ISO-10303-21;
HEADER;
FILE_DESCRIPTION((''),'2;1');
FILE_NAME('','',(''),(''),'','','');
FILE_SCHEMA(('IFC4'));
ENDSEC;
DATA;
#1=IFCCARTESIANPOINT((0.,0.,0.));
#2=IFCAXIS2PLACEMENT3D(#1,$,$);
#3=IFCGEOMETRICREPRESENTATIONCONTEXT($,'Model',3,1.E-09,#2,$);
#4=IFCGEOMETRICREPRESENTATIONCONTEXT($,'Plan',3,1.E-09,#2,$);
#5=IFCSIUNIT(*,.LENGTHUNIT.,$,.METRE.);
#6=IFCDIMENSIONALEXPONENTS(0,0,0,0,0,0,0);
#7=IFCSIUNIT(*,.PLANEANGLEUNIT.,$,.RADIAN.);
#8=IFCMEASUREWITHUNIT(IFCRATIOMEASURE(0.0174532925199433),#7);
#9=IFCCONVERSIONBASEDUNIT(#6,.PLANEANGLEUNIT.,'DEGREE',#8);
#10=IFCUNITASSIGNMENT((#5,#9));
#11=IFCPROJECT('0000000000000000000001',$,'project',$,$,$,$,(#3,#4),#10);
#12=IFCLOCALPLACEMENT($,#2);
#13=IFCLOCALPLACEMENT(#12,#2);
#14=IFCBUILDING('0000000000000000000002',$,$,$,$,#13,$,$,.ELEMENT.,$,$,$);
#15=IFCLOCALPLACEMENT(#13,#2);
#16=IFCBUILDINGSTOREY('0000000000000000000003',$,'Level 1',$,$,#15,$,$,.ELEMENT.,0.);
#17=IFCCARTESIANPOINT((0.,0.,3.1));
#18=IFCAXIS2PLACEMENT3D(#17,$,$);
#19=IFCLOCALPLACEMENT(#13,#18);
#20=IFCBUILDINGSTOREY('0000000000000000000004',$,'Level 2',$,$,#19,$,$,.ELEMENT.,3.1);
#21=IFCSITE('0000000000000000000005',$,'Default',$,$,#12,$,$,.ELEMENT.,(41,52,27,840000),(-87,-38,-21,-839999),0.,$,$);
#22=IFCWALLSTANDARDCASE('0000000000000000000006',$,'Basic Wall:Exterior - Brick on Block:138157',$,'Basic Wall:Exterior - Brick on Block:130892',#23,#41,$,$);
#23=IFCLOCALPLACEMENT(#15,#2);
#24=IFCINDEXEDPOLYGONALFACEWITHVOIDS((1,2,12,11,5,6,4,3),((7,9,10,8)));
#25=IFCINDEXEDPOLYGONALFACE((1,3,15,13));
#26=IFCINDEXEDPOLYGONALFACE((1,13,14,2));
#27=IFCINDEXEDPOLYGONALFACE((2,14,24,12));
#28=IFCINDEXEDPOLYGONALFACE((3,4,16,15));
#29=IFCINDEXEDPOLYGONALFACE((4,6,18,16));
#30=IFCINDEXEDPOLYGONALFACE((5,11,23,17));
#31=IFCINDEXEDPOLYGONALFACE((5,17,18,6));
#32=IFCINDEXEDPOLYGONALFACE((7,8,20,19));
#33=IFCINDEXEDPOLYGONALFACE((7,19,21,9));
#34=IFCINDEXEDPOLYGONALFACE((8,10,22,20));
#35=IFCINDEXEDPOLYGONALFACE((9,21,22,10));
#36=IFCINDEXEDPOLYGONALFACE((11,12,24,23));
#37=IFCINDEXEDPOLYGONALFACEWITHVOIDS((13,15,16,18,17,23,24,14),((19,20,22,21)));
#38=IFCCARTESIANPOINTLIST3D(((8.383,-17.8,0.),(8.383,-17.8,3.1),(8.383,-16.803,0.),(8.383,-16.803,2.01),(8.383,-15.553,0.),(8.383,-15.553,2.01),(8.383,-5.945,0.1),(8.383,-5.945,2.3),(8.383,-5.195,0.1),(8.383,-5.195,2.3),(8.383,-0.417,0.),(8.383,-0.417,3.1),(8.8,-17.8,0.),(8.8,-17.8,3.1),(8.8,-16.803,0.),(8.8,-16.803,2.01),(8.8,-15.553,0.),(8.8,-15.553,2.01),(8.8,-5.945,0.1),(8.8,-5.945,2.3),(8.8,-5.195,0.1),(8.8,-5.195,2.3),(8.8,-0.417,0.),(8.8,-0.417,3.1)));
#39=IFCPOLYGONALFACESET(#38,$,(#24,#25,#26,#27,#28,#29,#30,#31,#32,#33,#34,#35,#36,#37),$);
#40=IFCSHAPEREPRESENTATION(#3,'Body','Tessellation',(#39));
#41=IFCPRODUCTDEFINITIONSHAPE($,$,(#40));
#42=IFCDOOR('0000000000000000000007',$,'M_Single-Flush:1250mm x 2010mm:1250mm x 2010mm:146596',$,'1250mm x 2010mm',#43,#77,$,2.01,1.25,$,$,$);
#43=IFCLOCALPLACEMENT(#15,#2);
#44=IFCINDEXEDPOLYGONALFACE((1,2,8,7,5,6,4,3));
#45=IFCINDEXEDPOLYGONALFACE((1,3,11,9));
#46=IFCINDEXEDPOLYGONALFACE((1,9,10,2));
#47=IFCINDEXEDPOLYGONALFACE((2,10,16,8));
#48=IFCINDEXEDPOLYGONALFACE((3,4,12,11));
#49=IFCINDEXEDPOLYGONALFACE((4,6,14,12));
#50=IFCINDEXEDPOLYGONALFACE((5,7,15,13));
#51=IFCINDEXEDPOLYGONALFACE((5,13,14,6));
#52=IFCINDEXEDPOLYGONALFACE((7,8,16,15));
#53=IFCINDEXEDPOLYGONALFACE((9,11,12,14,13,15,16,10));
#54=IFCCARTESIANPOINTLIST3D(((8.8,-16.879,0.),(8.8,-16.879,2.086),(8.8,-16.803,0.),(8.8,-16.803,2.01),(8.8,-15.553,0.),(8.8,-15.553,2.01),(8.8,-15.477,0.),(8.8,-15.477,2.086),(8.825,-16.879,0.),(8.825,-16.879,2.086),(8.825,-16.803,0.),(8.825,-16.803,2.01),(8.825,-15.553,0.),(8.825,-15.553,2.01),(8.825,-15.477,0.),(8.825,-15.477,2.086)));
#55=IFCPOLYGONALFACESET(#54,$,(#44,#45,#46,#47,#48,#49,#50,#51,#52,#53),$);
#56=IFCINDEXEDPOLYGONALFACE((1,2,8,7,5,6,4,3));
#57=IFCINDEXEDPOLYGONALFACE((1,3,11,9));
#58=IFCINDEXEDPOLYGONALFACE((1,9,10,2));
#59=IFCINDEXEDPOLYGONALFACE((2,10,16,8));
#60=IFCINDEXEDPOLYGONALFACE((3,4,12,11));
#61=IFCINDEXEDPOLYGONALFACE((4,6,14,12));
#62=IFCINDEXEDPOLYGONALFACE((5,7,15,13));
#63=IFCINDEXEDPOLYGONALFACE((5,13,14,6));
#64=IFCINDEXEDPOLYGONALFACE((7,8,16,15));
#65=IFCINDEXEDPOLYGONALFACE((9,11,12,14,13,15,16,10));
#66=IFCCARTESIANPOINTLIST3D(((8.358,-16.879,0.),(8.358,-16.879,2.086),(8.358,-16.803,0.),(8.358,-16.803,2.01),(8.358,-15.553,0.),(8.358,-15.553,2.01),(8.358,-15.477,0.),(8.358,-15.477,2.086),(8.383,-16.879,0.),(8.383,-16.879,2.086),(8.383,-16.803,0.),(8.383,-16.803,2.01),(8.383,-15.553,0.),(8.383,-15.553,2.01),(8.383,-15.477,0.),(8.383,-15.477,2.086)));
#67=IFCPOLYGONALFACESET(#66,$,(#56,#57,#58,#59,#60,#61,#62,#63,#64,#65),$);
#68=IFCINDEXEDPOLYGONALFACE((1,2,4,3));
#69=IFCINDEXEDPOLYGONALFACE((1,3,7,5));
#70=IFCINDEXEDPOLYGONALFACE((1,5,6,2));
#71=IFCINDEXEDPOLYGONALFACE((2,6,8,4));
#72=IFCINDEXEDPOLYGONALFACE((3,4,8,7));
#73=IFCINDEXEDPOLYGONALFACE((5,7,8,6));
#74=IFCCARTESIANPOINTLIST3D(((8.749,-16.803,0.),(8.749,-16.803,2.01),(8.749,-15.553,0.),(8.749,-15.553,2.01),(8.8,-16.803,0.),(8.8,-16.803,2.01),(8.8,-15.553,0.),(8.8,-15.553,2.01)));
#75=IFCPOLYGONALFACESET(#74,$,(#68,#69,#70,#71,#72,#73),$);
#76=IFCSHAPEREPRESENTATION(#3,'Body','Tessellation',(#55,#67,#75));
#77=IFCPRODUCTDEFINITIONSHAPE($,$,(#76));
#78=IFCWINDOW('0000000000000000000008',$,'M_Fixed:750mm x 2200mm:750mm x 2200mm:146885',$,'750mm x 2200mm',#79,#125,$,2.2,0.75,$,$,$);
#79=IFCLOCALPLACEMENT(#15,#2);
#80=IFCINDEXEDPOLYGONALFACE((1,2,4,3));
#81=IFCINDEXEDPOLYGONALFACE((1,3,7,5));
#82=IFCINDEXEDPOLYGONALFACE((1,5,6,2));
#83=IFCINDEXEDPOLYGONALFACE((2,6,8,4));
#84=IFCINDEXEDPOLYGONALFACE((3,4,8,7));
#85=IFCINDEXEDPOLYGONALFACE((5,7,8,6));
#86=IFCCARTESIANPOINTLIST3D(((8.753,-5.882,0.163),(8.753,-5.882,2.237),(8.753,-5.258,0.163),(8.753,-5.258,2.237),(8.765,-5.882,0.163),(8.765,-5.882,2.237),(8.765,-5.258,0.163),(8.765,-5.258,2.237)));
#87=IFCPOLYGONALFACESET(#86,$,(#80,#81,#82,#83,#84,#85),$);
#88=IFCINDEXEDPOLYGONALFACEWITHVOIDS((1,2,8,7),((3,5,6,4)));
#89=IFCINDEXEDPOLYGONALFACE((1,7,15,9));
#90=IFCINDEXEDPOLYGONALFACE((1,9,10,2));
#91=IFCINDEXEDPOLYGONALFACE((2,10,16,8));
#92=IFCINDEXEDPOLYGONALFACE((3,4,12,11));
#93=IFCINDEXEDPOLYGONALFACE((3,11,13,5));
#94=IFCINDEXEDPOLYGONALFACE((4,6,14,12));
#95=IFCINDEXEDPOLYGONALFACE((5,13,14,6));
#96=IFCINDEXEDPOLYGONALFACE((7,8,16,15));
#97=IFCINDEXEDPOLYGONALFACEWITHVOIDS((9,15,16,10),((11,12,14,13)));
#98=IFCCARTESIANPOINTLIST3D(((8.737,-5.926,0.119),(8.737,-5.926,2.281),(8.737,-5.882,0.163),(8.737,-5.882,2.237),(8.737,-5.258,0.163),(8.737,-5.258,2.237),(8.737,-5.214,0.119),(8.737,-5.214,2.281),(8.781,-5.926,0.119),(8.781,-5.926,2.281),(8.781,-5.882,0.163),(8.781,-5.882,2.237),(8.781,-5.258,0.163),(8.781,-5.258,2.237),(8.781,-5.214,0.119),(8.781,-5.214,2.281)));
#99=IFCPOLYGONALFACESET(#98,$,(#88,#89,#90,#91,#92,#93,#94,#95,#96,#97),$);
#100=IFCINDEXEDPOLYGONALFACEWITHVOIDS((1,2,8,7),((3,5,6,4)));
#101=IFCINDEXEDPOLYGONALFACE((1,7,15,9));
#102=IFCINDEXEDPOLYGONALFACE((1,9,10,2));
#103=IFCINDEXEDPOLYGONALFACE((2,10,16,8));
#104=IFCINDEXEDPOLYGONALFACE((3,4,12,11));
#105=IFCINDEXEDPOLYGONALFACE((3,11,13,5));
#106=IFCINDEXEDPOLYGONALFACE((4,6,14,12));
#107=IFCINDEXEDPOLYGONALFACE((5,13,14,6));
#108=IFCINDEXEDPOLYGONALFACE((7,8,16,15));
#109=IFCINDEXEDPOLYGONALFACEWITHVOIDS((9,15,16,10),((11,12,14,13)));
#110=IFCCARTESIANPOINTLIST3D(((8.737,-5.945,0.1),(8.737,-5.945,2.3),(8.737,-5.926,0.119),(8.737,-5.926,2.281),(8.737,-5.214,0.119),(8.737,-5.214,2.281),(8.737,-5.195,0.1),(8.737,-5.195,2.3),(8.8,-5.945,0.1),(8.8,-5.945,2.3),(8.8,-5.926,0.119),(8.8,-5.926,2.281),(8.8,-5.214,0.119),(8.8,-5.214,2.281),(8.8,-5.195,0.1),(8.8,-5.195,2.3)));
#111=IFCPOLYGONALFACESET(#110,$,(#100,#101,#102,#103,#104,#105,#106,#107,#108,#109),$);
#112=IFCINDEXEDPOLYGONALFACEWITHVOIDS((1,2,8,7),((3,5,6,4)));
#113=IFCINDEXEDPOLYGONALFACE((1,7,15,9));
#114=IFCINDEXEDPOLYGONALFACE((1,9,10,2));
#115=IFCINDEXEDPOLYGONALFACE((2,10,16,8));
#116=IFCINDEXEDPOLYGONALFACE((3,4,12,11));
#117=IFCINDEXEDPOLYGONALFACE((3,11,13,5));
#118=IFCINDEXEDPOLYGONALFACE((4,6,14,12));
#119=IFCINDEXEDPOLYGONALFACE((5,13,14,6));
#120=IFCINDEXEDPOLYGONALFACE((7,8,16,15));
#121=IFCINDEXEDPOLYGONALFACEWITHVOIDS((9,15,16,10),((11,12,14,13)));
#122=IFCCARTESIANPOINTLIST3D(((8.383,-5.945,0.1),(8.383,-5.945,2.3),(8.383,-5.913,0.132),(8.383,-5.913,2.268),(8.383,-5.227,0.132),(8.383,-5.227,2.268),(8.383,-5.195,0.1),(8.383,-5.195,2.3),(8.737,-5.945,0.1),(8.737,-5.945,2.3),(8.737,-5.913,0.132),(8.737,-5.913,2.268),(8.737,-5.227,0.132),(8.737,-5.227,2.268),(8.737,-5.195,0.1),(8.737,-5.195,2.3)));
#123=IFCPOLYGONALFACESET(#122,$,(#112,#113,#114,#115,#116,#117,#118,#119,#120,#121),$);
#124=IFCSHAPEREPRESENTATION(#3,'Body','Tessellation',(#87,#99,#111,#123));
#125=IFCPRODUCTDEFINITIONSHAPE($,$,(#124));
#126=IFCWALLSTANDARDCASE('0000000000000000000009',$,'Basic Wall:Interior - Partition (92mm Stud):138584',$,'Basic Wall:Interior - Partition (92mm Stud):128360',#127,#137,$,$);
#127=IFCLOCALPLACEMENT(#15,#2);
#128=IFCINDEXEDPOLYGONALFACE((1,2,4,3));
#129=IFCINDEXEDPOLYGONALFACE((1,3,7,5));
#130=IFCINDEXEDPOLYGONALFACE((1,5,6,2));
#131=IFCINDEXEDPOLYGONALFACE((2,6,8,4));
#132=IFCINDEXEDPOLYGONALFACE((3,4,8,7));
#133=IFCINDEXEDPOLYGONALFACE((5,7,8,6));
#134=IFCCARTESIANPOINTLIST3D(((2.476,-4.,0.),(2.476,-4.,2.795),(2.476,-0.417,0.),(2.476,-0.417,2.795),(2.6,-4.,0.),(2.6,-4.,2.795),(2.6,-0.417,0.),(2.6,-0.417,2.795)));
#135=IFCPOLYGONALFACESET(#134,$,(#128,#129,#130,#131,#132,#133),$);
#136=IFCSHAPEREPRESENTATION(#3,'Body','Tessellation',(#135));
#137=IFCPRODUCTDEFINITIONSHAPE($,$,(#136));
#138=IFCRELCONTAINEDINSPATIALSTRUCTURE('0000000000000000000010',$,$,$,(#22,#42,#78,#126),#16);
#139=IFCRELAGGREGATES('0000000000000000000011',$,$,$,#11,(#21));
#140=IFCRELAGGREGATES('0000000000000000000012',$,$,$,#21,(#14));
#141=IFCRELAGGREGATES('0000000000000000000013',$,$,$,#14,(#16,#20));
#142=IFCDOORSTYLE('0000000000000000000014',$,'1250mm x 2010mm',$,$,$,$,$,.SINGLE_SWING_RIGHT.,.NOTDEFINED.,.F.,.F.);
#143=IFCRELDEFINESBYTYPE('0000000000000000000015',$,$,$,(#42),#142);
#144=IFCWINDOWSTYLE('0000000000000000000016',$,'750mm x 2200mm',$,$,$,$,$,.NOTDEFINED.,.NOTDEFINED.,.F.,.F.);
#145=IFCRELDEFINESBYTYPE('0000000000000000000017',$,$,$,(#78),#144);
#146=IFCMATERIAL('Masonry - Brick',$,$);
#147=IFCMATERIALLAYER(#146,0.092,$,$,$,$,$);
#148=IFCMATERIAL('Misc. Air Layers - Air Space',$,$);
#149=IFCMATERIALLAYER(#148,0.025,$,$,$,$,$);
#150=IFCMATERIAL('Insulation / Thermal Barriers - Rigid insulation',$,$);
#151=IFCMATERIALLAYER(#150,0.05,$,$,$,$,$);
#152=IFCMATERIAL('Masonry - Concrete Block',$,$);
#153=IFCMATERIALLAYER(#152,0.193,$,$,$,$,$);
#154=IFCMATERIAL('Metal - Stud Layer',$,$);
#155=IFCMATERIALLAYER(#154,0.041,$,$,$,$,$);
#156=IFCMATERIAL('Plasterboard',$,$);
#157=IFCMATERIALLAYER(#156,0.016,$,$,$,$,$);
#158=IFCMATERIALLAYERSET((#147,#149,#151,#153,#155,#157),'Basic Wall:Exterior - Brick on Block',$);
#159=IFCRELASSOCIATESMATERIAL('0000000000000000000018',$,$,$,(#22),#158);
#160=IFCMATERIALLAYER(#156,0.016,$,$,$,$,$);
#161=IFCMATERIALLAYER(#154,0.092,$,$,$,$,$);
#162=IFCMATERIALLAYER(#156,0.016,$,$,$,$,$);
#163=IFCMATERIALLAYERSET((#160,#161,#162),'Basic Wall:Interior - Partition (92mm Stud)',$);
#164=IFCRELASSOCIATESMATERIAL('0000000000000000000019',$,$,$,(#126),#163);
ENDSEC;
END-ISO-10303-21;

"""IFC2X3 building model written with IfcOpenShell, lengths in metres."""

from ifc_helpers import new_model, entity, si_unit, converted_unit, frame, frame_2d, origin, origin_2d_with_axis, place, context, project, spatial, polyline, rectangle, outline, extrude, source, transform, mapped, material, layer, layer_set, layer_usage, type_object, type_shapes, element, fill, save


model = new_model("IFC2X3")

# Units and contexts
model_context = context("Model", 3, precision=1e-09, world=origin())
plan_context = context("Plan", 3, precision=1e-09, world=origin())
ifc_project = project(units=[si_unit("LENGTHUNIT", "METRE"), converted_unit("PLANEANGLEUNIT", "DEGREE", entity("IfcRatioMeasure", 0.0174532925199433), si_unit("PLANEANGLEUNIT", "RADIAN"), dimensions=[0, 0, 0, 0, 0, 0, 0])], contexts=[model_context, plan_context])

# Site, building, storey
site_placement = place(None, origin())
site = spatial("IfcSite", under=ifc_project, at=site_placement, Name="Default", CompositionType="ELEMENT", RefLatitude=(41, 52, 27, 840000), RefLongitude=(-87, -38, -21, -839999), RefElevation=0.0)
building_placement = place(site_placement, origin())
building = spatial("IfcBuilding", under=site, at=building_placement, CompositionType="ELEMENT")
storey_1_placement = place(building_placement, origin())
storey_1 = spatial("IfcBuildingStorey", under=building, at=storey_1_placement, Name="Level 1", CompositionType="ELEMENT", Elevation=0.0)

# Shared definitions
ifc_material_1 = material(Name="Masonry - Brick")
ifc_layer_1 = layer(ifc_material_1, 0.092)
ifc_material_2 = material(Name="Misc. Air Layers - Air Space")
ifc_layer_2 = layer(ifc_material_2, 0.025)
ifc_material_3 = material(Name="Insulation / Thermal Barriers - Rigid insulation")
ifc_layer_3 = layer(ifc_material_3, 0.05)
ifc_material_4 = material(Name="Masonry - Concrete Block")
ifc_layer_4 = layer(ifc_material_4, 0.193)
ifc_material_5 = material(Name="Metal - Stud Layer")
ifc_layer_5 = layer(ifc_material_5, 0.041)
ifc_material_6 = material(Name="Plasterboard")
ifc_layer_6 = layer(ifc_material_6, 0.016)
ifc_layer_set_1 = layer_set([ifc_layer_1, ifc_layer_2, ifc_layer_3, ifc_layer_4, ifc_layer_5, ifc_layer_6], Name="Basic Wall:Exterior - Brick on Block")

# Wall, openings, door, window
ifc_layer_usage_1 = layer_usage(ifc_layer_set_1, "AXIS2", "NEGATIVE", 0.2085)
wall_1_placement = place(storey_1_placement, frame((8.5915, -0.417, 0.0), z_axis=(0.0, 0.0, 1.0), x_axis=(0.0, -1.0, 0.0)))
wall_1 = element("IfcWallStandardCase", 1, at=wall_1_placement, inside=storey_1, material=ifc_layer_usage_1, Name="Basic Wall:Exterior - Brick on Block:138157", ObjectType="Basic Wall:Exterior - Brick on Block:130892", context=model_context, shape_type="SweptSolid", body=[
    extrude(rectangle(XDim=17.383, YDim=0.417, at=frame_2d((8.6915, 0.0), x_axis=(-1.0, 0.0))), origin(), (0.0, 0.0, 1.0), 3.1),
])
opening_1_placement = place(wall_1_placement, frame((15.136, -0.2085, 0.0)))
opening_1 = element("IfcOpeningElement", 2, at=opening_1_placement, cuts=wall_1, ObjectType="Opening", context=model_context, shape_type="SweptSolid", body=[
    extrude(rectangle(XDim=1.25, YDim=2.01, at=frame_2d((1.005, 0.625), x_axis=(0.0, 1.0))), frame((0.0, 0.0, 0.0), z_axis=(0.0, 1.0, 0.0), x_axis=(0.0, 0.0, 1.0)), (0.0, 0.0, 1.0), 0.417),
])
opening_2_placement = place(wall_1_placement, frame((4.778, -0.2085, 0.1)))
opening_2 = element("IfcOpeningElement", 3, at=opening_2_placement, cuts=wall_1, ObjectType="Opening", context=model_context, shape_type="SweptSolid", body=[
    extrude(rectangle(XDim=2.2, YDim=0.75, at=frame_2d((1.1, 0.375), x_axis=(1.0, 0.0))), frame((0.0, 0.0, 0.0), z_axis=(0.0, 1.0, 0.0), x_axis=(0.0, 0.0, 1.0)), (0.0, 0.0, 1.0), 0.417),
])
door_style_1 = type_object("IfcDoorStyle", Name="1250mm x 2010mm", ConstructionType="NOTDEFINED", OperationType="SINGLE_SWING_RIGHT", ParameterTakesPrecedence=False, Sizeable=False)
shared_shape_1 = source(origin(), model_context, "Body", "SweptSolid", [
    extrude(outline(polyline([(-0.701, -1.062), (0.701, -1.062), (0.701, 1.024), (0.625, 1.024), (0.625, -0.986), (-0.625, -0.986), (-0.625, 1.024), (-0.701, 1.024), (-0.701, -1.062)])), frame((0.625, 0.417, 1.024), z_axis=(0.0, 1.0, 0.0), x_axis=(1.0, 0.0, 0.0)), (0.0, 0.0, 1.0), 0.025),
    extrude(outline(polyline([(-1.062, -0.701), (1.024, -0.701), (1.024, -0.625), (-0.986, -0.625), (-0.986, 0.625), (1.024, 0.625), (1.024, 0.701), (-1.062, 0.701), (-1.062, -0.701)])), frame((0.625, -0.025, 1.024), z_axis=(0.0, 1.0, 0.0), x_axis=(0.0, 0.0, -1.0)), (0.0, 0.0, 1.0), 0.025),
    extrude(rectangle(XDim=0.051, YDim=1.25, at=origin_2d_with_axis()), frame((0.625, 0.3915, 0.0), z_axis=(0.0, 0.0, 1.0), x_axis=(0.0, 1.0, 0.0)), (0.0, 0.0, 1.0), 2.01),
])
type_shapes(door_style_1, [shared_shape_1])
door_1_placement = place(opening_1_placement, origin())
door_1 = element("IfcDoor", 4, at=door_1_placement, inside=storey_1, type_object=door_style_1, Name="M_Single-Flush:1250mm x 2010mm:1250mm x 2010mm:146596", ObjectType="1250mm x 2010mm", OverallHeight=2.01, OverallWidth=1.25, context=model_context, shape_type="MappedRepresentation", body=[
    mapped(shared_shape_1, transform((0.0, 0.0, 0.0), scale=1.0)),
])
fill(opening_1, door_1)
window_style_1 = type_object("IfcWindowStyle", Name="750mm x 2200mm", ConstructionType="NOTDEFINED", OperationType="NOTDEFINED", ParameterTakesPrecedence=False, Sizeable=False)
shared_shape_2 = source(origin(), model_context, "Body", "SweptSolid", [
    extrude(rectangle(XDim=0.012, YDim=0.624, at=origin_2d_with_axis()), frame((0.375, 0.376, 0.063), z_axis=(0.0, 0.0, 1.0), x_axis=(0.0, -1.0, 0.0)), (0.0, 0.0, 1.0), 2.074),
    extrude(outline(polyline([(-0.356, -1.081), (0.356, -1.081), (0.356, 1.081), (-0.356, 1.081), (-0.356, -1.081)]), holes=[polyline([(-0.312, -1.037), (-0.312, 1.037), (0.312, 1.037), (0.312, -1.037), (-0.312, -1.037)])]), frame((0.375, 0.354, 1.1), z_axis=(0.0, 1.0, 0.0), x_axis=(1.0, 0.0, 0.0)), (0.0, 0.0, 1.0), 0.044),
    extrude(outline(polyline([(-0.375, -1.1), (0.375, -1.1), (0.375, 1.1), (-0.375, 1.1), (-0.375, -1.1)]), holes=[polyline([(-0.356, -1.081), (-0.356, 1.081), (0.356, 1.081), (0.356, -1.081), (-0.356, -1.081)])]), frame((0.375, 0.354, 1.1), z_axis=(0.0, 1.0, 0.0), x_axis=(1.0, 0.0, 0.0)), (0.0, 0.0, 1.0), 0.063),
    extrude(outline(polyline([(-0.375, -1.1), (0.375, -1.1), (0.375, 1.1), (-0.375, 1.1), (-0.375, -1.1)]), holes=[polyline([(-0.343, -1.068), (-0.343, 1.068), (0.343, 1.068), (0.343, -1.068), (-0.343, -1.068)])]), frame((0.375, 0.0, 1.1), z_axis=(0.0, 1.0, 0.0), x_axis=(1.0, 0.0, 0.0)), (0.0, 0.0, 1.0), 0.354),
])
type_shapes(window_style_1, [shared_shape_2])
window_1_placement = place(opening_2_placement, origin())
window_1 = element("IfcWindow", 5, at=window_1_placement, inside=storey_1, type_object=window_style_1, Name="M_Fixed:750mm x 2200mm:750mm x 2200mm:146885", ObjectType="750mm x 2200mm", OverallHeight=2.2, OverallWidth=0.75, context=model_context, shape_type="MappedRepresentation", body=[
    mapped(shared_shape_2, transform((0.0, 0.0, 0.0), scale=1.0)),
])
fill(opening_2, window_1)

# Wall
ifc_layer_7 = layer(ifc_material_6, 0.016)
ifc_layer_8 = layer(ifc_material_5, 0.092)
ifc_layer_9 = layer(ifc_material_6, 0.016)
ifc_layer_set_2 = layer_set([ifc_layer_7, ifc_layer_8, ifc_layer_9], Name="Basic Wall:Interior - Partition (92mm Stud)")
ifc_layer_usage_2 = layer_usage(ifc_layer_set_2, "AXIS2", "NEGATIVE", 0.062)
wall_2_placement = place(storey_1_placement, frame((2.538, -0.417, 0.0), z_axis=(0.0, 0.0, 1.0), x_axis=(0.0, -1.0, 0.0)))
element("IfcWallStandardCase", 6, at=wall_2_placement, inside=storey_1, material=ifc_layer_usage_2, Name="Basic Wall:Interior - Partition (92mm Stud):138584", ObjectType="Basic Wall:Interior - Partition (92mm Stud):128360", context=model_context, shape_type="SweptSolid", body=[
    extrude(rectangle(XDim=3.583, YDim=0.124, at=frame_2d((1.7915, 0.0), x_axis=(-1.0, 0.0))), origin(), (0.0, 0.0, 1.0), 2.795),
])

# Shared definitions
storey_2_placement = place(building_placement, frame((0.0, 0.0, 3.1)))
storey_2 = spatial("IfcBuildingStorey", under=building, at=storey_2_placement, Name="Level 2", CompositionType="ELEMENT", Elevation=3.1)

save(model, "model.ifc")
